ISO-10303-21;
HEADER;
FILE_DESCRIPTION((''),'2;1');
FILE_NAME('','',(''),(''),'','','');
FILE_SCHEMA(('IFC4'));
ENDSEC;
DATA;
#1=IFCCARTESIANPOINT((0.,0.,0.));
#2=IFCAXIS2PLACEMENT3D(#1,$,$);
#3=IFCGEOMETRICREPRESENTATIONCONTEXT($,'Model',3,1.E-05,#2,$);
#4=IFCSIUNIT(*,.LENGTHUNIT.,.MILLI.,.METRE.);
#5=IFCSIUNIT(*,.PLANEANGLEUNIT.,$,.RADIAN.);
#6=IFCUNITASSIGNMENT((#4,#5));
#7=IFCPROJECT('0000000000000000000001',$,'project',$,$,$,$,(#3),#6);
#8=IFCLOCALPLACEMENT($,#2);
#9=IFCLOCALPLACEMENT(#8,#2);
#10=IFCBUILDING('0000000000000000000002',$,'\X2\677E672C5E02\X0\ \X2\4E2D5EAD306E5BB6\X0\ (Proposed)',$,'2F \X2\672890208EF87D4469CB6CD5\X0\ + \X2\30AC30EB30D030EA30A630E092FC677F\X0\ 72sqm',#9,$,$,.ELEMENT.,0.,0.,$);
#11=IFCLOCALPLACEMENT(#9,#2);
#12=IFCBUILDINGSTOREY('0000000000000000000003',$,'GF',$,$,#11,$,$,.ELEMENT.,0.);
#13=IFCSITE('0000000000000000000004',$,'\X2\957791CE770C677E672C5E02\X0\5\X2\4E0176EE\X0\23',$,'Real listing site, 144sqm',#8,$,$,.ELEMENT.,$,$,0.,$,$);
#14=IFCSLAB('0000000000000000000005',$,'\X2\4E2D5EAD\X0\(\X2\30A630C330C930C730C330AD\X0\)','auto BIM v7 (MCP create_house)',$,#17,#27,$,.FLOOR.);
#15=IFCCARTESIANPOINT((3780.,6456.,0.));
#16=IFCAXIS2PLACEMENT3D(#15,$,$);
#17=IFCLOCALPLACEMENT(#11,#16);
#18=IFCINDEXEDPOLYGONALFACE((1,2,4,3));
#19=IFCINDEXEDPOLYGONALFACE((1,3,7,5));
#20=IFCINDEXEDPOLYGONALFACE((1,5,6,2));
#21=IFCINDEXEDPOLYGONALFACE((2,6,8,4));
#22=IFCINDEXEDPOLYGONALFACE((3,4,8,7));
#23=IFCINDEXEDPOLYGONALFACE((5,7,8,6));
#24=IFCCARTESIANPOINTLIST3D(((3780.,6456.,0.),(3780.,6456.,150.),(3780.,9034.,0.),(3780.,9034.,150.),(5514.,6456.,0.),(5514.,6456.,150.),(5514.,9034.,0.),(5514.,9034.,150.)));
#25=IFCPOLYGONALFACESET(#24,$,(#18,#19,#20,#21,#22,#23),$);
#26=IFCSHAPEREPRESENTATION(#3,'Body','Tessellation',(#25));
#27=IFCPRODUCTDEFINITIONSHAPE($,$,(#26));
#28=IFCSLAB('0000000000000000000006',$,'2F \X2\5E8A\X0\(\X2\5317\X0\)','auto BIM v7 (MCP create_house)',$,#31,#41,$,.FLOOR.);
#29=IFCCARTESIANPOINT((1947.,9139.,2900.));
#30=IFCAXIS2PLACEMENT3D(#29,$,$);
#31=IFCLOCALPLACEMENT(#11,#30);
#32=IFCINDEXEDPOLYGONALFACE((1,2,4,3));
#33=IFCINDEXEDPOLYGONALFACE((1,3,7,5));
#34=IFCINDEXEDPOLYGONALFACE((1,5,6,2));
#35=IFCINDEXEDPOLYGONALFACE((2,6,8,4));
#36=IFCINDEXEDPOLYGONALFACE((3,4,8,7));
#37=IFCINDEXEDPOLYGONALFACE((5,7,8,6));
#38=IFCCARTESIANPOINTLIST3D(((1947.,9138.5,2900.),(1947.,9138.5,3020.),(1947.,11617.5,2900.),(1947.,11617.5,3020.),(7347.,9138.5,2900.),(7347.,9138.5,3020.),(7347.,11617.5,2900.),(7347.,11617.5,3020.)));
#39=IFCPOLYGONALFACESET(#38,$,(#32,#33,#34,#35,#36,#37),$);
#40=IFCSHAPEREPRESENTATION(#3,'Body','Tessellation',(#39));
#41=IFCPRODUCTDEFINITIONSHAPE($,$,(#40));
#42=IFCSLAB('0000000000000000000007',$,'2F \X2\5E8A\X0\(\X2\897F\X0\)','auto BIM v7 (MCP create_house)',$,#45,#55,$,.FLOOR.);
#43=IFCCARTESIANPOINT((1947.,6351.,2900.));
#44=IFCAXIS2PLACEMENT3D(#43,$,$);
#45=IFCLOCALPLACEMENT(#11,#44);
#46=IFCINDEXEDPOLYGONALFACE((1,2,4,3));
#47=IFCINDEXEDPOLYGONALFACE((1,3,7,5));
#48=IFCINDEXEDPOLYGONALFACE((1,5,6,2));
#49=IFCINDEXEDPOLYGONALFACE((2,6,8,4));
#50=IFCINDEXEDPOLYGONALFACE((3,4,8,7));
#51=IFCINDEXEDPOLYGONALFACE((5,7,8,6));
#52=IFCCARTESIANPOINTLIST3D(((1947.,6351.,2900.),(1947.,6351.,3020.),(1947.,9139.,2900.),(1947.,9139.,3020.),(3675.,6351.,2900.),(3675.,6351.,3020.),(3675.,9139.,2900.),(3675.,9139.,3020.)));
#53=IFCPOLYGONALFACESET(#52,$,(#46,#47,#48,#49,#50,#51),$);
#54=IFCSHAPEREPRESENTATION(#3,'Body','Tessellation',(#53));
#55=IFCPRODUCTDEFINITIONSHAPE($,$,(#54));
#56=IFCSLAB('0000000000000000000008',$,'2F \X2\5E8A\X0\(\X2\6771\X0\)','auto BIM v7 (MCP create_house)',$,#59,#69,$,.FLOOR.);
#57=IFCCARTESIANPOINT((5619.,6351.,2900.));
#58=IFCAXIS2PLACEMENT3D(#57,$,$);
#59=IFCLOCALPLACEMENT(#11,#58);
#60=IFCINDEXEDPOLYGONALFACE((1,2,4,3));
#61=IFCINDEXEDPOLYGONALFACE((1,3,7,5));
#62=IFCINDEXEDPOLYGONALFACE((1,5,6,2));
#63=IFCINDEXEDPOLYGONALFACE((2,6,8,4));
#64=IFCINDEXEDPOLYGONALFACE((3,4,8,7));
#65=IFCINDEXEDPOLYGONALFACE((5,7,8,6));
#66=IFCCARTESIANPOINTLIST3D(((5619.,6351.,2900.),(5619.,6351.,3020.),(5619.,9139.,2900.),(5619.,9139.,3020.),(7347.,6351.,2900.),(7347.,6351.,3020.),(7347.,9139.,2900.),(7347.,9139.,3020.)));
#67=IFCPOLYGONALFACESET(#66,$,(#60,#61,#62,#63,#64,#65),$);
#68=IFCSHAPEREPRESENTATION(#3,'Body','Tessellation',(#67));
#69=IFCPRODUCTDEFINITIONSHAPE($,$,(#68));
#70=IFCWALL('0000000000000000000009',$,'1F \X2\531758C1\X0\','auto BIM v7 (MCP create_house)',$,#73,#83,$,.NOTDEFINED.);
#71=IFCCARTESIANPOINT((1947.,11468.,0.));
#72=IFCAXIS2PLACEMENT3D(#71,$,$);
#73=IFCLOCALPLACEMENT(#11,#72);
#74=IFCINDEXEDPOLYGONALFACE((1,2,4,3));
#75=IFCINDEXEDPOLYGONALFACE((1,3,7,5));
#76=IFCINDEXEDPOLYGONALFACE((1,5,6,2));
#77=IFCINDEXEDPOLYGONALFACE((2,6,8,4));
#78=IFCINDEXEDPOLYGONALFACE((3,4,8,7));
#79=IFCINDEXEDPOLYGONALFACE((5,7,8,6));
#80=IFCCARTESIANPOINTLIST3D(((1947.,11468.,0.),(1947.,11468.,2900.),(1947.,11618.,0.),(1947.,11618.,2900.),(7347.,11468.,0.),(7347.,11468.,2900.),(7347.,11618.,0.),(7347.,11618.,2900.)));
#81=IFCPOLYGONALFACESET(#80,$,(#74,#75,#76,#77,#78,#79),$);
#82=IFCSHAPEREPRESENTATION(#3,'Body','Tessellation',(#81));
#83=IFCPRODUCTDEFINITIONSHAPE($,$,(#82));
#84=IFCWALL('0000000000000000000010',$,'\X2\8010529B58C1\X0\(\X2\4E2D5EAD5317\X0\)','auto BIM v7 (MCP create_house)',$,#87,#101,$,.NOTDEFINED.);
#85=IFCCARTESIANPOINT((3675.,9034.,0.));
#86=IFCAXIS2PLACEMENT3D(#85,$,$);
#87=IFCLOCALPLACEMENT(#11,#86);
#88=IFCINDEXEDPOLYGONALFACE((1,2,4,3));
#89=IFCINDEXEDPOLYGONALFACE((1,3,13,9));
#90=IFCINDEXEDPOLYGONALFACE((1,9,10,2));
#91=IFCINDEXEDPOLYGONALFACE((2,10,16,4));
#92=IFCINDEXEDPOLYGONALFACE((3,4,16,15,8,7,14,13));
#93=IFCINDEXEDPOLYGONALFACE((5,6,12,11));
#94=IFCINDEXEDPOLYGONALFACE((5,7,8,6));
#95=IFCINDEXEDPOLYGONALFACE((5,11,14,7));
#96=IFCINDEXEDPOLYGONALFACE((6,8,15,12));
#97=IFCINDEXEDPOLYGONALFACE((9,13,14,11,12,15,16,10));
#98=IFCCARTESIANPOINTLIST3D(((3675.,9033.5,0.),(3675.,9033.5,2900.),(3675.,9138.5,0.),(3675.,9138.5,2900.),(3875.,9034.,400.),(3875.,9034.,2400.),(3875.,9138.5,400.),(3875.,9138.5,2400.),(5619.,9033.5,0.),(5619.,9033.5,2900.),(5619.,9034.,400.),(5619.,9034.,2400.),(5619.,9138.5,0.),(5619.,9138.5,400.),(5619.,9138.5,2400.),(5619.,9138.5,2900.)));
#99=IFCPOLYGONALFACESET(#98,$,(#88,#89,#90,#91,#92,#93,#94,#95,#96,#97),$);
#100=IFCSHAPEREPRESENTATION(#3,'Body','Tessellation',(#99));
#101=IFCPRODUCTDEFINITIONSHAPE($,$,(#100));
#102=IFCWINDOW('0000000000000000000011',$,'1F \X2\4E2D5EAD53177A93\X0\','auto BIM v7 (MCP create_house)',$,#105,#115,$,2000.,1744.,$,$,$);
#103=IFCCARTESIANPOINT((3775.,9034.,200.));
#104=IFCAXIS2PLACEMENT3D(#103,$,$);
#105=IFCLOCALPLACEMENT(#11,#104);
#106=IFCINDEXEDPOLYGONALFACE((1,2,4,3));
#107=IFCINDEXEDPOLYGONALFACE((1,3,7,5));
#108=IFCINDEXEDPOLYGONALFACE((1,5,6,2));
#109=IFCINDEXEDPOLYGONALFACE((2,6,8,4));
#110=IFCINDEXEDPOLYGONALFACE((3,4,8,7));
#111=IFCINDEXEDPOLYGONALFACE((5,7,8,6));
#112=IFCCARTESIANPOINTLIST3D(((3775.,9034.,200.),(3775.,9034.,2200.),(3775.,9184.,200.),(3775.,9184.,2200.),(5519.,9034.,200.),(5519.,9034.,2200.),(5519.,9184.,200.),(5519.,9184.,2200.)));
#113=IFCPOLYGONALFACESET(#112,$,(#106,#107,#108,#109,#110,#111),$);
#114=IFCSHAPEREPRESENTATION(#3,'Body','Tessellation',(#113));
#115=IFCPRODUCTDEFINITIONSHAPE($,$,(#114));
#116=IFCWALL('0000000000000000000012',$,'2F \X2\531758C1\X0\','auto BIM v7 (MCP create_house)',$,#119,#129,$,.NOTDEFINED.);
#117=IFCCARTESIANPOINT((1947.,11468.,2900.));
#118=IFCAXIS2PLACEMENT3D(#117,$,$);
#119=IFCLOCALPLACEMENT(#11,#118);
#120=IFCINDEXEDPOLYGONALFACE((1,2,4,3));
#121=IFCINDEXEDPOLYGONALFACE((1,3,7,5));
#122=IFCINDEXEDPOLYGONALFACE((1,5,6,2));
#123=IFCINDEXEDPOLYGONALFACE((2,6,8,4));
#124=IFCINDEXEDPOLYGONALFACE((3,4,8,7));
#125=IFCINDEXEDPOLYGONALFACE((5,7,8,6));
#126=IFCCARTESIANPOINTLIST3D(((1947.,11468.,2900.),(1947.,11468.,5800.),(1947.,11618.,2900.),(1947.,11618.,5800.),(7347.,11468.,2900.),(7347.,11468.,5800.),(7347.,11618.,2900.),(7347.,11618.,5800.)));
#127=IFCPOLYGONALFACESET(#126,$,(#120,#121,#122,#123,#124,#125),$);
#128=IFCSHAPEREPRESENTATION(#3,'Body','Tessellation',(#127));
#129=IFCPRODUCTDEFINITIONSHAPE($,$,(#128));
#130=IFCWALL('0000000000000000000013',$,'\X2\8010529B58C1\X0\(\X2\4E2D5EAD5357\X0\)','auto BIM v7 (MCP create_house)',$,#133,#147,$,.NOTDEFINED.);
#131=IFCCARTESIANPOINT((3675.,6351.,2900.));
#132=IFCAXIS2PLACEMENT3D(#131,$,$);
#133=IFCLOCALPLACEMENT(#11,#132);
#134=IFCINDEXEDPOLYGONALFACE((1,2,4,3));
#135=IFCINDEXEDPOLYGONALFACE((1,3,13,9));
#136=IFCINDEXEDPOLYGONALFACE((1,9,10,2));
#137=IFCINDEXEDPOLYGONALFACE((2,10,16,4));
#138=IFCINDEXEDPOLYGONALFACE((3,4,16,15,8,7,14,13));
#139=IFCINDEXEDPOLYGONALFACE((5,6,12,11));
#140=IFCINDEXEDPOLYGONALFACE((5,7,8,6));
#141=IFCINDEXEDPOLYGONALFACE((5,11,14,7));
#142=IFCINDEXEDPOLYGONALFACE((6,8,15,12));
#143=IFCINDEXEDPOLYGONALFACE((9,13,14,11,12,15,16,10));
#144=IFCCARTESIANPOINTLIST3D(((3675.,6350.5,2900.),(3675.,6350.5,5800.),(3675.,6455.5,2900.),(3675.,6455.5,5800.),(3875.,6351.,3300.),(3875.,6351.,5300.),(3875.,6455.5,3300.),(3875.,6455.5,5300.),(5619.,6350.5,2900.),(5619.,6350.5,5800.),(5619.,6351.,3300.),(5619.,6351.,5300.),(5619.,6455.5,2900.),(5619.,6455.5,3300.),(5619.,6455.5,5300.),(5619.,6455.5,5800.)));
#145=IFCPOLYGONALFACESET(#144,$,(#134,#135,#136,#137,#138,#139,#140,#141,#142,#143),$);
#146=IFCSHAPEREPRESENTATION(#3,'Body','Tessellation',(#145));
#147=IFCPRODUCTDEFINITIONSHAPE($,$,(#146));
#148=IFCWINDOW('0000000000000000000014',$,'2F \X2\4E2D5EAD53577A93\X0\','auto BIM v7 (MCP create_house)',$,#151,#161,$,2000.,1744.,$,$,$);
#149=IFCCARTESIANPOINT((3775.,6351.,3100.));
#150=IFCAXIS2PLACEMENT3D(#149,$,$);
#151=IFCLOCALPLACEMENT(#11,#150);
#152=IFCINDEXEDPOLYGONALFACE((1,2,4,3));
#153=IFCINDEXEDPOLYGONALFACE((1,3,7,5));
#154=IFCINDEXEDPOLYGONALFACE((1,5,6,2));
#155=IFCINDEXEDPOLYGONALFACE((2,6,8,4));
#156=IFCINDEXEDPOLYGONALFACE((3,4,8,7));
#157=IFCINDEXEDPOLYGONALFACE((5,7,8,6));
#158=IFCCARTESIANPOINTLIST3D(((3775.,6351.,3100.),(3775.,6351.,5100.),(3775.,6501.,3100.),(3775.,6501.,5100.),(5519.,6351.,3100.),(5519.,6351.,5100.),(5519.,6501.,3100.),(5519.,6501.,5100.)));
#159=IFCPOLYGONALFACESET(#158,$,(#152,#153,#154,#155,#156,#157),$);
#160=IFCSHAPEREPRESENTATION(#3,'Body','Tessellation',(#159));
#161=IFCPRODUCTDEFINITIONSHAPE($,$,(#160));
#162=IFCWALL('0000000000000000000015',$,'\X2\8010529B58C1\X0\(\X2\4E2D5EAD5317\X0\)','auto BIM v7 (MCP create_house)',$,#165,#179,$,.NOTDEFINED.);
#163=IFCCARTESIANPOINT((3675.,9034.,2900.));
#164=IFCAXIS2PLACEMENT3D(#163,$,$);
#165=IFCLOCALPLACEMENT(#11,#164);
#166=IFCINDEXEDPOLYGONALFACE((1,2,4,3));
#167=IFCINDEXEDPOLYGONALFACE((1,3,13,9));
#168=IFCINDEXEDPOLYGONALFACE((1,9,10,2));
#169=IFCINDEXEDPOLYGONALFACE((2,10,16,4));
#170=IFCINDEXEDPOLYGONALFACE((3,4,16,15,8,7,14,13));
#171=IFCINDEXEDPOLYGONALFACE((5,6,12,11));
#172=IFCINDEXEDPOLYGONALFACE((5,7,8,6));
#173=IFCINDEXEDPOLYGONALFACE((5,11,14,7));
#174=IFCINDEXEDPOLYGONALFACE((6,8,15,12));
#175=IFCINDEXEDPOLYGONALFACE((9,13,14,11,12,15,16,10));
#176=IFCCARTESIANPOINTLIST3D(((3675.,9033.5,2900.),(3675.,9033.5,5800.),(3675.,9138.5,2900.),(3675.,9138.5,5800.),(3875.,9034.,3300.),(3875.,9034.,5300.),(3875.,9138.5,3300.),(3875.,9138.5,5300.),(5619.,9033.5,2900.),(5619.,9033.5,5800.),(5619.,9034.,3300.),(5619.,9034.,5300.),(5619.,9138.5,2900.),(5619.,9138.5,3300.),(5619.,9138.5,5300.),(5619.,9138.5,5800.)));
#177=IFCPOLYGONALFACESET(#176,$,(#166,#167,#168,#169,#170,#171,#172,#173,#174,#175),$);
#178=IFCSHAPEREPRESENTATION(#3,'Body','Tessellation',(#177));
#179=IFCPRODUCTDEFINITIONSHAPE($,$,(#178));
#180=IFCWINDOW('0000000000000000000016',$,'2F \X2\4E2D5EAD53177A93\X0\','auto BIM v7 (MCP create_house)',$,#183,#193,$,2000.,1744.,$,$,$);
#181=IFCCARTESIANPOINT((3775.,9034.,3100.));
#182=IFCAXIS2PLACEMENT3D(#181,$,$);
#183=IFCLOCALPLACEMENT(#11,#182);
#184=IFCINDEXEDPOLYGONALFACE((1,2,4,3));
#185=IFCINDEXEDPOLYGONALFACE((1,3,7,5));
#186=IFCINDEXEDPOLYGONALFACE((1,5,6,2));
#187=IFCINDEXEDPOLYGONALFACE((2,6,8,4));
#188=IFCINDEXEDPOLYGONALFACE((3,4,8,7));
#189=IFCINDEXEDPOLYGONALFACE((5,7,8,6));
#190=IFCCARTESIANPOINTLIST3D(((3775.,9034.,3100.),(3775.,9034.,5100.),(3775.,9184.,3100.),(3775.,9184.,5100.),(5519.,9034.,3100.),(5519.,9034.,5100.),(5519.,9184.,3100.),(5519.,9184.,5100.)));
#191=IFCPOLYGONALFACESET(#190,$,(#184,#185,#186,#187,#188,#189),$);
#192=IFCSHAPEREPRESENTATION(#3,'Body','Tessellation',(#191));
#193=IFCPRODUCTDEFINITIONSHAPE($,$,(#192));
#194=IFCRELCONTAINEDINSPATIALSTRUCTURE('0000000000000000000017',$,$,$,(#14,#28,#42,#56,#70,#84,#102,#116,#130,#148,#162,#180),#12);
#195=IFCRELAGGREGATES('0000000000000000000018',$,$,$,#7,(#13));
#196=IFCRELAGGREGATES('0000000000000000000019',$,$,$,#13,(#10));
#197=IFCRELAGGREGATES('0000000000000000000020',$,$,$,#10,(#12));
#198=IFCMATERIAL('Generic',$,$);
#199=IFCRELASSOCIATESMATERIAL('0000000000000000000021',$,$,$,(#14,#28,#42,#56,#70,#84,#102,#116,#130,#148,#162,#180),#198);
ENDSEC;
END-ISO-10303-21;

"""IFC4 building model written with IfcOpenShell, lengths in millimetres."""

from ifc_helpers import new_model, si_unit, frame, frame_2d, origin, place, context, project, spatial, rectangle, extrude, material, element, fill, save


model = new_model("IFC4")

# Units and contexts
model_context = context("Model", 3, precision=1e-05, world=origin())
ifc_project = project(units=[si_unit("LENGTHUNIT", "METRE", prefix="MILLI"), si_unit("PLANEANGLEUNIT", "RADIAN")], contexts=[model_context])

# Site, building, storey
site_placement = place(None, origin())
site = spatial("IfcSite", under=ifc_project, at=site_placement, Name="長野県松本市5丁目23", ObjectType="Real listing site, 144sqm", CompositionType="ELEMENT", RefElevation=0.0)
building_placement = place(site_placement, origin())
building = spatial("IfcBuilding", under=site, at=building_placement, Name="松本市 中庭の家 (Proposed)", ObjectType="2F 木造軸組構法 + ガルバリウム鋼板 72sqm", CompositionType="ELEMENT", ElevationOfRefHeight=0.0, ElevationOfTerrain=0.0)
storey_placement = place(building_placement, origin())
storey = spatial("IfcBuildingStorey", under=building, at=storey_placement, Name="GF", CompositionType="ELEMENT", Elevation=0.0)

# Slabs
ifc_material = material(Name="Generic")
slab_1_placement = place(storey_placement, frame((3780.0, 6456.0, 0.0)))
element("IfcSlab", 1, at=slab_1_placement, inside=storey, material=ifc_material, Name="中庭(ウッドデッキ)", Description="auto BIM v7 (MCP create_house)", PredefinedType="FLOOR", context=model_context, shape_type="SweptSolid", body=[
    extrude(rectangle(XDim=1734.0, YDim=2578.0, at=frame_2d((867.0, 1289.0))), frame((3780.0, 6456.0, 0.0)), (0.0, 0.0, 1.0), 150.0),
])
slab_2_placement = place(storey_placement, frame((1947.0, 9139.0, 2900.0)))
element("IfcSlab", 2, at=slab_2_placement, inside=storey, material=ifc_material, Name="2F 床(北)", Description="auto BIM v7 (MCP create_house)", PredefinedType="FLOOR", context=model_context, shape_type="SweptSolid", body=[
    extrude(rectangle(XDim=5400.0, YDim=2479.0, at=frame_2d((2700.0, 1239.0))), frame((1947.0, 9139.0, 2900.0)), (0.0, 0.0, 1.0), 120.0),
])
slab_3_placement = place(storey_placement, frame((1947.0, 6351.0, 2900.0)))
element("IfcSlab", 3, at=slab_3_placement, inside=storey, material=ifc_material, Name="2F 床(西)", Description="auto BIM v7 (MCP create_house)", PredefinedType="FLOOR", context=model_context, shape_type="SweptSolid", body=[
    extrude(rectangle(XDim=1728.0, YDim=2788.0, at=frame_2d((864.0, 1394.0))), frame((1947.0, 6351.0, 2900.0)), (0.0, 0.0, 1.0), 120.0),
])
slab_4_placement = place(storey_placement, frame((5619.0, 6351.0, 2900.0)))
element("IfcSlab", 4, at=slab_4_placement, inside=storey, material=ifc_material, Name="2F 床(東)", Description="auto BIM v7 (MCP create_house)", PredefinedType="FLOOR", context=model_context, shape_type="SweptSolid", body=[
    extrude(rectangle(XDim=1728.0, YDim=2788.0, at=frame_2d((864.0, 1394.0))), frame((5619.0, 6351.0, 2900.0)), (0.0, 0.0, 1.0), 120.0),
])

# Wall
wall_1_placement = place(storey_placement, frame((1947.0, 11468.0, 0.0)))
element("IfcWall", 5, at=wall_1_placement, inside=storey, material=ifc_material, Name="1F 北壁", Description="auto BIM v7 (MCP create_house)", PredefinedType="NOTDEFINED", context=model_context, shape_type="SweptSolid", body=[
    extrude(rectangle(XDim=5400.0, YDim=150.0, at=frame_2d((2700.0, 75.0))), frame((1947.0, 11468.0, 0.0)), (0.0, 0.0, 1.0), 2900.0),
])

# Wall, opening, window
wall_2_placement = place(storey_placement, frame((3675.0, 9034.0, 0.0)))
wall_2 = element("IfcWall", 6, at=wall_2_placement, inside=storey, material=ifc_material, Name="耐力壁(中庭北)", Description="auto BIM v7 (MCP create_house)", PredefinedType="NOTDEFINED", context=model_context, shape_type="SweptSolid", body=[
    extrude(rectangle(XDim=1944.0, YDim=105.0, at=frame_2d((972.0, 52.0))), frame((3675.0, 9034.0, 0.0)), (0.0, 0.0, 1.0), 2900.0),
])
opening_1_placement = place(storey_placement, frame((3775.0, 9034.0, 200.0)))
opening_1 = element("IfcOpeningElement", 7, at=opening_1_placement, cuts=wall_2, PredefinedType="NOTDEFINED", context=model_context, shape_type="SweptSolid", body=[
    extrude(rectangle(XDim=1744.0, YDim=150.0, at=frame_2d((872.0, 75.0))), frame((3775.0, 9034.0, 200.0)), (0.0, 0.0, 1.0), 2000.0),
])
window_1_placement = place(storey_placement, frame((3775.0, 9034.0, 200.0)))
window_1 = element("IfcWindow", 8, at=window_1_placement, inside=storey, material=ifc_material, Name="1F 中庭北窓", Description="auto BIM v7 (MCP create_house)", OverallHeight=2000.0, OverallWidth=1744.0, context=model_context, shape_type="SweptSolid", body=[
    extrude(rectangle(XDim=1744.0, YDim=150.0, at=frame_2d((872.0, 75.0))), frame((3775.0, 9034.0, 200.0)), (0.0, 0.0, 1.0), 2000.0),
])
fill(opening_1, window_1)

# Wall
wall_3_placement = place(storey_placement, frame((1947.0, 11468.0, 2900.0)))
element("IfcWall", 9, at=wall_3_placement, inside=storey, material=ifc_material, Name="2F 北壁", Description="auto BIM v7 (MCP create_house)", PredefinedType="NOTDEFINED", context=model_context, shape_type="SweptSolid", body=[
    extrude(rectangle(XDim=5400.0, YDim=150.0, at=frame_2d((2700.0, 75.0))), frame((1947.0, 11468.0, 2900.0)), (0.0, 0.0, 1.0), 2900.0),
])

# Walls, openings, windows
wall_4_placement = place(storey_placement, frame((3675.0, 6351.0, 2900.0)))
wall_4 = element("IfcWall", 10, at=wall_4_placement, inside=storey, material=ifc_material, Name="耐力壁(中庭南)", Description="auto BIM v7 (MCP create_house)", PredefinedType="NOTDEFINED", context=model_context, shape_type="SweptSolid", body=[
    extrude(rectangle(XDim=1944.0, YDim=105.0, at=frame_2d((972.0, 52.0))), frame((3675.0, 6351.0, 2900.0)), (0.0, 0.0, 1.0), 2900.0),
])
opening_2_placement = place(storey_placement, frame((3775.0, 6351.0, 3100.0)))
opening_2 = element("IfcOpeningElement", 11, at=opening_2_placement, cuts=wall_4, PredefinedType="NOTDEFINED", context=model_context, shape_type="SweptSolid", body=[
    extrude(rectangle(XDim=1744.0, YDim=150.0, at=frame_2d((872.0, 75.0))), frame((3775.0, 6351.0, 3100.0)), (0.0, 0.0, 1.0), 2000.0),
])
window_2_placement = place(storey_placement, frame((3775.0, 6351.0, 3100.0)))
window_2 = element("IfcWindow", 12, at=window_2_placement, inside=storey, material=ifc_material, Name="2F 中庭南窓", Description="auto BIM v7 (MCP create_house)", OverallHeight=2000.0, OverallWidth=1744.0, context=model_context, shape_type="SweptSolid", body=[
    extrude(rectangle(XDim=1744.0, YDim=150.0, at=frame_2d((872.0, 75.0))), frame((3775.0, 6351.0, 3100.0)), (0.0, 0.0, 1.0), 2000.0),
])
fill(opening_2, window_2)
wall_5_placement = place(storey_placement, frame((3675.0, 9034.0, 2900.0)))
wall_5 = element("IfcWall", 13, at=wall_5_placement, inside=storey, material=ifc_material, Name="耐力壁(中庭北)", Description="auto BIM v7 (MCP create_house)", PredefinedType="NOTDEFINED", context=model_context, shape_type="SweptSolid", body=[
    extrude(rectangle(XDim=1944.0, YDim=105.0, at=frame_2d((972.0, 52.0))), frame((3675.0, 9034.0, 2900.0)), (0.0, 0.0, 1.0), 2900.0),
])
opening_3_placement = place(storey_placement, frame((3775.0, 9034.0, 3100.0)))
opening_3 = element("IfcOpeningElement", 14, at=opening_3_placement, cuts=wall_5, PredefinedType="NOTDEFINED", context=model_context, shape_type="SweptSolid", body=[
    extrude(rectangle(XDim=1744.0, YDim=150.0, at=frame_2d((872.0, 75.0))), frame((3775.0, 9034.0, 3100.0)), (0.0, 0.0, 1.0), 2000.0),
])
window_3_placement = place(storey_placement, frame((3775.0, 9034.0, 3100.0)))
window_3 = element("IfcWindow", 15, at=window_3_placement, inside=storey, material=ifc_material, Name="2F 中庭北窓", Description="auto BIM v7 (MCP create_house)", OverallHeight=2000.0, OverallWidth=1744.0, context=model_context, shape_type="SweptSolid", body=[
    extrude(rectangle(XDim=1744.0, YDim=150.0, at=frame_2d((872.0, 75.0))), frame((3775.0, 9034.0, 3100.0)), (0.0, 0.0, 1.0), 2000.0),
])
fill(opening_3, window_3)

save(model, "model.ifc")
